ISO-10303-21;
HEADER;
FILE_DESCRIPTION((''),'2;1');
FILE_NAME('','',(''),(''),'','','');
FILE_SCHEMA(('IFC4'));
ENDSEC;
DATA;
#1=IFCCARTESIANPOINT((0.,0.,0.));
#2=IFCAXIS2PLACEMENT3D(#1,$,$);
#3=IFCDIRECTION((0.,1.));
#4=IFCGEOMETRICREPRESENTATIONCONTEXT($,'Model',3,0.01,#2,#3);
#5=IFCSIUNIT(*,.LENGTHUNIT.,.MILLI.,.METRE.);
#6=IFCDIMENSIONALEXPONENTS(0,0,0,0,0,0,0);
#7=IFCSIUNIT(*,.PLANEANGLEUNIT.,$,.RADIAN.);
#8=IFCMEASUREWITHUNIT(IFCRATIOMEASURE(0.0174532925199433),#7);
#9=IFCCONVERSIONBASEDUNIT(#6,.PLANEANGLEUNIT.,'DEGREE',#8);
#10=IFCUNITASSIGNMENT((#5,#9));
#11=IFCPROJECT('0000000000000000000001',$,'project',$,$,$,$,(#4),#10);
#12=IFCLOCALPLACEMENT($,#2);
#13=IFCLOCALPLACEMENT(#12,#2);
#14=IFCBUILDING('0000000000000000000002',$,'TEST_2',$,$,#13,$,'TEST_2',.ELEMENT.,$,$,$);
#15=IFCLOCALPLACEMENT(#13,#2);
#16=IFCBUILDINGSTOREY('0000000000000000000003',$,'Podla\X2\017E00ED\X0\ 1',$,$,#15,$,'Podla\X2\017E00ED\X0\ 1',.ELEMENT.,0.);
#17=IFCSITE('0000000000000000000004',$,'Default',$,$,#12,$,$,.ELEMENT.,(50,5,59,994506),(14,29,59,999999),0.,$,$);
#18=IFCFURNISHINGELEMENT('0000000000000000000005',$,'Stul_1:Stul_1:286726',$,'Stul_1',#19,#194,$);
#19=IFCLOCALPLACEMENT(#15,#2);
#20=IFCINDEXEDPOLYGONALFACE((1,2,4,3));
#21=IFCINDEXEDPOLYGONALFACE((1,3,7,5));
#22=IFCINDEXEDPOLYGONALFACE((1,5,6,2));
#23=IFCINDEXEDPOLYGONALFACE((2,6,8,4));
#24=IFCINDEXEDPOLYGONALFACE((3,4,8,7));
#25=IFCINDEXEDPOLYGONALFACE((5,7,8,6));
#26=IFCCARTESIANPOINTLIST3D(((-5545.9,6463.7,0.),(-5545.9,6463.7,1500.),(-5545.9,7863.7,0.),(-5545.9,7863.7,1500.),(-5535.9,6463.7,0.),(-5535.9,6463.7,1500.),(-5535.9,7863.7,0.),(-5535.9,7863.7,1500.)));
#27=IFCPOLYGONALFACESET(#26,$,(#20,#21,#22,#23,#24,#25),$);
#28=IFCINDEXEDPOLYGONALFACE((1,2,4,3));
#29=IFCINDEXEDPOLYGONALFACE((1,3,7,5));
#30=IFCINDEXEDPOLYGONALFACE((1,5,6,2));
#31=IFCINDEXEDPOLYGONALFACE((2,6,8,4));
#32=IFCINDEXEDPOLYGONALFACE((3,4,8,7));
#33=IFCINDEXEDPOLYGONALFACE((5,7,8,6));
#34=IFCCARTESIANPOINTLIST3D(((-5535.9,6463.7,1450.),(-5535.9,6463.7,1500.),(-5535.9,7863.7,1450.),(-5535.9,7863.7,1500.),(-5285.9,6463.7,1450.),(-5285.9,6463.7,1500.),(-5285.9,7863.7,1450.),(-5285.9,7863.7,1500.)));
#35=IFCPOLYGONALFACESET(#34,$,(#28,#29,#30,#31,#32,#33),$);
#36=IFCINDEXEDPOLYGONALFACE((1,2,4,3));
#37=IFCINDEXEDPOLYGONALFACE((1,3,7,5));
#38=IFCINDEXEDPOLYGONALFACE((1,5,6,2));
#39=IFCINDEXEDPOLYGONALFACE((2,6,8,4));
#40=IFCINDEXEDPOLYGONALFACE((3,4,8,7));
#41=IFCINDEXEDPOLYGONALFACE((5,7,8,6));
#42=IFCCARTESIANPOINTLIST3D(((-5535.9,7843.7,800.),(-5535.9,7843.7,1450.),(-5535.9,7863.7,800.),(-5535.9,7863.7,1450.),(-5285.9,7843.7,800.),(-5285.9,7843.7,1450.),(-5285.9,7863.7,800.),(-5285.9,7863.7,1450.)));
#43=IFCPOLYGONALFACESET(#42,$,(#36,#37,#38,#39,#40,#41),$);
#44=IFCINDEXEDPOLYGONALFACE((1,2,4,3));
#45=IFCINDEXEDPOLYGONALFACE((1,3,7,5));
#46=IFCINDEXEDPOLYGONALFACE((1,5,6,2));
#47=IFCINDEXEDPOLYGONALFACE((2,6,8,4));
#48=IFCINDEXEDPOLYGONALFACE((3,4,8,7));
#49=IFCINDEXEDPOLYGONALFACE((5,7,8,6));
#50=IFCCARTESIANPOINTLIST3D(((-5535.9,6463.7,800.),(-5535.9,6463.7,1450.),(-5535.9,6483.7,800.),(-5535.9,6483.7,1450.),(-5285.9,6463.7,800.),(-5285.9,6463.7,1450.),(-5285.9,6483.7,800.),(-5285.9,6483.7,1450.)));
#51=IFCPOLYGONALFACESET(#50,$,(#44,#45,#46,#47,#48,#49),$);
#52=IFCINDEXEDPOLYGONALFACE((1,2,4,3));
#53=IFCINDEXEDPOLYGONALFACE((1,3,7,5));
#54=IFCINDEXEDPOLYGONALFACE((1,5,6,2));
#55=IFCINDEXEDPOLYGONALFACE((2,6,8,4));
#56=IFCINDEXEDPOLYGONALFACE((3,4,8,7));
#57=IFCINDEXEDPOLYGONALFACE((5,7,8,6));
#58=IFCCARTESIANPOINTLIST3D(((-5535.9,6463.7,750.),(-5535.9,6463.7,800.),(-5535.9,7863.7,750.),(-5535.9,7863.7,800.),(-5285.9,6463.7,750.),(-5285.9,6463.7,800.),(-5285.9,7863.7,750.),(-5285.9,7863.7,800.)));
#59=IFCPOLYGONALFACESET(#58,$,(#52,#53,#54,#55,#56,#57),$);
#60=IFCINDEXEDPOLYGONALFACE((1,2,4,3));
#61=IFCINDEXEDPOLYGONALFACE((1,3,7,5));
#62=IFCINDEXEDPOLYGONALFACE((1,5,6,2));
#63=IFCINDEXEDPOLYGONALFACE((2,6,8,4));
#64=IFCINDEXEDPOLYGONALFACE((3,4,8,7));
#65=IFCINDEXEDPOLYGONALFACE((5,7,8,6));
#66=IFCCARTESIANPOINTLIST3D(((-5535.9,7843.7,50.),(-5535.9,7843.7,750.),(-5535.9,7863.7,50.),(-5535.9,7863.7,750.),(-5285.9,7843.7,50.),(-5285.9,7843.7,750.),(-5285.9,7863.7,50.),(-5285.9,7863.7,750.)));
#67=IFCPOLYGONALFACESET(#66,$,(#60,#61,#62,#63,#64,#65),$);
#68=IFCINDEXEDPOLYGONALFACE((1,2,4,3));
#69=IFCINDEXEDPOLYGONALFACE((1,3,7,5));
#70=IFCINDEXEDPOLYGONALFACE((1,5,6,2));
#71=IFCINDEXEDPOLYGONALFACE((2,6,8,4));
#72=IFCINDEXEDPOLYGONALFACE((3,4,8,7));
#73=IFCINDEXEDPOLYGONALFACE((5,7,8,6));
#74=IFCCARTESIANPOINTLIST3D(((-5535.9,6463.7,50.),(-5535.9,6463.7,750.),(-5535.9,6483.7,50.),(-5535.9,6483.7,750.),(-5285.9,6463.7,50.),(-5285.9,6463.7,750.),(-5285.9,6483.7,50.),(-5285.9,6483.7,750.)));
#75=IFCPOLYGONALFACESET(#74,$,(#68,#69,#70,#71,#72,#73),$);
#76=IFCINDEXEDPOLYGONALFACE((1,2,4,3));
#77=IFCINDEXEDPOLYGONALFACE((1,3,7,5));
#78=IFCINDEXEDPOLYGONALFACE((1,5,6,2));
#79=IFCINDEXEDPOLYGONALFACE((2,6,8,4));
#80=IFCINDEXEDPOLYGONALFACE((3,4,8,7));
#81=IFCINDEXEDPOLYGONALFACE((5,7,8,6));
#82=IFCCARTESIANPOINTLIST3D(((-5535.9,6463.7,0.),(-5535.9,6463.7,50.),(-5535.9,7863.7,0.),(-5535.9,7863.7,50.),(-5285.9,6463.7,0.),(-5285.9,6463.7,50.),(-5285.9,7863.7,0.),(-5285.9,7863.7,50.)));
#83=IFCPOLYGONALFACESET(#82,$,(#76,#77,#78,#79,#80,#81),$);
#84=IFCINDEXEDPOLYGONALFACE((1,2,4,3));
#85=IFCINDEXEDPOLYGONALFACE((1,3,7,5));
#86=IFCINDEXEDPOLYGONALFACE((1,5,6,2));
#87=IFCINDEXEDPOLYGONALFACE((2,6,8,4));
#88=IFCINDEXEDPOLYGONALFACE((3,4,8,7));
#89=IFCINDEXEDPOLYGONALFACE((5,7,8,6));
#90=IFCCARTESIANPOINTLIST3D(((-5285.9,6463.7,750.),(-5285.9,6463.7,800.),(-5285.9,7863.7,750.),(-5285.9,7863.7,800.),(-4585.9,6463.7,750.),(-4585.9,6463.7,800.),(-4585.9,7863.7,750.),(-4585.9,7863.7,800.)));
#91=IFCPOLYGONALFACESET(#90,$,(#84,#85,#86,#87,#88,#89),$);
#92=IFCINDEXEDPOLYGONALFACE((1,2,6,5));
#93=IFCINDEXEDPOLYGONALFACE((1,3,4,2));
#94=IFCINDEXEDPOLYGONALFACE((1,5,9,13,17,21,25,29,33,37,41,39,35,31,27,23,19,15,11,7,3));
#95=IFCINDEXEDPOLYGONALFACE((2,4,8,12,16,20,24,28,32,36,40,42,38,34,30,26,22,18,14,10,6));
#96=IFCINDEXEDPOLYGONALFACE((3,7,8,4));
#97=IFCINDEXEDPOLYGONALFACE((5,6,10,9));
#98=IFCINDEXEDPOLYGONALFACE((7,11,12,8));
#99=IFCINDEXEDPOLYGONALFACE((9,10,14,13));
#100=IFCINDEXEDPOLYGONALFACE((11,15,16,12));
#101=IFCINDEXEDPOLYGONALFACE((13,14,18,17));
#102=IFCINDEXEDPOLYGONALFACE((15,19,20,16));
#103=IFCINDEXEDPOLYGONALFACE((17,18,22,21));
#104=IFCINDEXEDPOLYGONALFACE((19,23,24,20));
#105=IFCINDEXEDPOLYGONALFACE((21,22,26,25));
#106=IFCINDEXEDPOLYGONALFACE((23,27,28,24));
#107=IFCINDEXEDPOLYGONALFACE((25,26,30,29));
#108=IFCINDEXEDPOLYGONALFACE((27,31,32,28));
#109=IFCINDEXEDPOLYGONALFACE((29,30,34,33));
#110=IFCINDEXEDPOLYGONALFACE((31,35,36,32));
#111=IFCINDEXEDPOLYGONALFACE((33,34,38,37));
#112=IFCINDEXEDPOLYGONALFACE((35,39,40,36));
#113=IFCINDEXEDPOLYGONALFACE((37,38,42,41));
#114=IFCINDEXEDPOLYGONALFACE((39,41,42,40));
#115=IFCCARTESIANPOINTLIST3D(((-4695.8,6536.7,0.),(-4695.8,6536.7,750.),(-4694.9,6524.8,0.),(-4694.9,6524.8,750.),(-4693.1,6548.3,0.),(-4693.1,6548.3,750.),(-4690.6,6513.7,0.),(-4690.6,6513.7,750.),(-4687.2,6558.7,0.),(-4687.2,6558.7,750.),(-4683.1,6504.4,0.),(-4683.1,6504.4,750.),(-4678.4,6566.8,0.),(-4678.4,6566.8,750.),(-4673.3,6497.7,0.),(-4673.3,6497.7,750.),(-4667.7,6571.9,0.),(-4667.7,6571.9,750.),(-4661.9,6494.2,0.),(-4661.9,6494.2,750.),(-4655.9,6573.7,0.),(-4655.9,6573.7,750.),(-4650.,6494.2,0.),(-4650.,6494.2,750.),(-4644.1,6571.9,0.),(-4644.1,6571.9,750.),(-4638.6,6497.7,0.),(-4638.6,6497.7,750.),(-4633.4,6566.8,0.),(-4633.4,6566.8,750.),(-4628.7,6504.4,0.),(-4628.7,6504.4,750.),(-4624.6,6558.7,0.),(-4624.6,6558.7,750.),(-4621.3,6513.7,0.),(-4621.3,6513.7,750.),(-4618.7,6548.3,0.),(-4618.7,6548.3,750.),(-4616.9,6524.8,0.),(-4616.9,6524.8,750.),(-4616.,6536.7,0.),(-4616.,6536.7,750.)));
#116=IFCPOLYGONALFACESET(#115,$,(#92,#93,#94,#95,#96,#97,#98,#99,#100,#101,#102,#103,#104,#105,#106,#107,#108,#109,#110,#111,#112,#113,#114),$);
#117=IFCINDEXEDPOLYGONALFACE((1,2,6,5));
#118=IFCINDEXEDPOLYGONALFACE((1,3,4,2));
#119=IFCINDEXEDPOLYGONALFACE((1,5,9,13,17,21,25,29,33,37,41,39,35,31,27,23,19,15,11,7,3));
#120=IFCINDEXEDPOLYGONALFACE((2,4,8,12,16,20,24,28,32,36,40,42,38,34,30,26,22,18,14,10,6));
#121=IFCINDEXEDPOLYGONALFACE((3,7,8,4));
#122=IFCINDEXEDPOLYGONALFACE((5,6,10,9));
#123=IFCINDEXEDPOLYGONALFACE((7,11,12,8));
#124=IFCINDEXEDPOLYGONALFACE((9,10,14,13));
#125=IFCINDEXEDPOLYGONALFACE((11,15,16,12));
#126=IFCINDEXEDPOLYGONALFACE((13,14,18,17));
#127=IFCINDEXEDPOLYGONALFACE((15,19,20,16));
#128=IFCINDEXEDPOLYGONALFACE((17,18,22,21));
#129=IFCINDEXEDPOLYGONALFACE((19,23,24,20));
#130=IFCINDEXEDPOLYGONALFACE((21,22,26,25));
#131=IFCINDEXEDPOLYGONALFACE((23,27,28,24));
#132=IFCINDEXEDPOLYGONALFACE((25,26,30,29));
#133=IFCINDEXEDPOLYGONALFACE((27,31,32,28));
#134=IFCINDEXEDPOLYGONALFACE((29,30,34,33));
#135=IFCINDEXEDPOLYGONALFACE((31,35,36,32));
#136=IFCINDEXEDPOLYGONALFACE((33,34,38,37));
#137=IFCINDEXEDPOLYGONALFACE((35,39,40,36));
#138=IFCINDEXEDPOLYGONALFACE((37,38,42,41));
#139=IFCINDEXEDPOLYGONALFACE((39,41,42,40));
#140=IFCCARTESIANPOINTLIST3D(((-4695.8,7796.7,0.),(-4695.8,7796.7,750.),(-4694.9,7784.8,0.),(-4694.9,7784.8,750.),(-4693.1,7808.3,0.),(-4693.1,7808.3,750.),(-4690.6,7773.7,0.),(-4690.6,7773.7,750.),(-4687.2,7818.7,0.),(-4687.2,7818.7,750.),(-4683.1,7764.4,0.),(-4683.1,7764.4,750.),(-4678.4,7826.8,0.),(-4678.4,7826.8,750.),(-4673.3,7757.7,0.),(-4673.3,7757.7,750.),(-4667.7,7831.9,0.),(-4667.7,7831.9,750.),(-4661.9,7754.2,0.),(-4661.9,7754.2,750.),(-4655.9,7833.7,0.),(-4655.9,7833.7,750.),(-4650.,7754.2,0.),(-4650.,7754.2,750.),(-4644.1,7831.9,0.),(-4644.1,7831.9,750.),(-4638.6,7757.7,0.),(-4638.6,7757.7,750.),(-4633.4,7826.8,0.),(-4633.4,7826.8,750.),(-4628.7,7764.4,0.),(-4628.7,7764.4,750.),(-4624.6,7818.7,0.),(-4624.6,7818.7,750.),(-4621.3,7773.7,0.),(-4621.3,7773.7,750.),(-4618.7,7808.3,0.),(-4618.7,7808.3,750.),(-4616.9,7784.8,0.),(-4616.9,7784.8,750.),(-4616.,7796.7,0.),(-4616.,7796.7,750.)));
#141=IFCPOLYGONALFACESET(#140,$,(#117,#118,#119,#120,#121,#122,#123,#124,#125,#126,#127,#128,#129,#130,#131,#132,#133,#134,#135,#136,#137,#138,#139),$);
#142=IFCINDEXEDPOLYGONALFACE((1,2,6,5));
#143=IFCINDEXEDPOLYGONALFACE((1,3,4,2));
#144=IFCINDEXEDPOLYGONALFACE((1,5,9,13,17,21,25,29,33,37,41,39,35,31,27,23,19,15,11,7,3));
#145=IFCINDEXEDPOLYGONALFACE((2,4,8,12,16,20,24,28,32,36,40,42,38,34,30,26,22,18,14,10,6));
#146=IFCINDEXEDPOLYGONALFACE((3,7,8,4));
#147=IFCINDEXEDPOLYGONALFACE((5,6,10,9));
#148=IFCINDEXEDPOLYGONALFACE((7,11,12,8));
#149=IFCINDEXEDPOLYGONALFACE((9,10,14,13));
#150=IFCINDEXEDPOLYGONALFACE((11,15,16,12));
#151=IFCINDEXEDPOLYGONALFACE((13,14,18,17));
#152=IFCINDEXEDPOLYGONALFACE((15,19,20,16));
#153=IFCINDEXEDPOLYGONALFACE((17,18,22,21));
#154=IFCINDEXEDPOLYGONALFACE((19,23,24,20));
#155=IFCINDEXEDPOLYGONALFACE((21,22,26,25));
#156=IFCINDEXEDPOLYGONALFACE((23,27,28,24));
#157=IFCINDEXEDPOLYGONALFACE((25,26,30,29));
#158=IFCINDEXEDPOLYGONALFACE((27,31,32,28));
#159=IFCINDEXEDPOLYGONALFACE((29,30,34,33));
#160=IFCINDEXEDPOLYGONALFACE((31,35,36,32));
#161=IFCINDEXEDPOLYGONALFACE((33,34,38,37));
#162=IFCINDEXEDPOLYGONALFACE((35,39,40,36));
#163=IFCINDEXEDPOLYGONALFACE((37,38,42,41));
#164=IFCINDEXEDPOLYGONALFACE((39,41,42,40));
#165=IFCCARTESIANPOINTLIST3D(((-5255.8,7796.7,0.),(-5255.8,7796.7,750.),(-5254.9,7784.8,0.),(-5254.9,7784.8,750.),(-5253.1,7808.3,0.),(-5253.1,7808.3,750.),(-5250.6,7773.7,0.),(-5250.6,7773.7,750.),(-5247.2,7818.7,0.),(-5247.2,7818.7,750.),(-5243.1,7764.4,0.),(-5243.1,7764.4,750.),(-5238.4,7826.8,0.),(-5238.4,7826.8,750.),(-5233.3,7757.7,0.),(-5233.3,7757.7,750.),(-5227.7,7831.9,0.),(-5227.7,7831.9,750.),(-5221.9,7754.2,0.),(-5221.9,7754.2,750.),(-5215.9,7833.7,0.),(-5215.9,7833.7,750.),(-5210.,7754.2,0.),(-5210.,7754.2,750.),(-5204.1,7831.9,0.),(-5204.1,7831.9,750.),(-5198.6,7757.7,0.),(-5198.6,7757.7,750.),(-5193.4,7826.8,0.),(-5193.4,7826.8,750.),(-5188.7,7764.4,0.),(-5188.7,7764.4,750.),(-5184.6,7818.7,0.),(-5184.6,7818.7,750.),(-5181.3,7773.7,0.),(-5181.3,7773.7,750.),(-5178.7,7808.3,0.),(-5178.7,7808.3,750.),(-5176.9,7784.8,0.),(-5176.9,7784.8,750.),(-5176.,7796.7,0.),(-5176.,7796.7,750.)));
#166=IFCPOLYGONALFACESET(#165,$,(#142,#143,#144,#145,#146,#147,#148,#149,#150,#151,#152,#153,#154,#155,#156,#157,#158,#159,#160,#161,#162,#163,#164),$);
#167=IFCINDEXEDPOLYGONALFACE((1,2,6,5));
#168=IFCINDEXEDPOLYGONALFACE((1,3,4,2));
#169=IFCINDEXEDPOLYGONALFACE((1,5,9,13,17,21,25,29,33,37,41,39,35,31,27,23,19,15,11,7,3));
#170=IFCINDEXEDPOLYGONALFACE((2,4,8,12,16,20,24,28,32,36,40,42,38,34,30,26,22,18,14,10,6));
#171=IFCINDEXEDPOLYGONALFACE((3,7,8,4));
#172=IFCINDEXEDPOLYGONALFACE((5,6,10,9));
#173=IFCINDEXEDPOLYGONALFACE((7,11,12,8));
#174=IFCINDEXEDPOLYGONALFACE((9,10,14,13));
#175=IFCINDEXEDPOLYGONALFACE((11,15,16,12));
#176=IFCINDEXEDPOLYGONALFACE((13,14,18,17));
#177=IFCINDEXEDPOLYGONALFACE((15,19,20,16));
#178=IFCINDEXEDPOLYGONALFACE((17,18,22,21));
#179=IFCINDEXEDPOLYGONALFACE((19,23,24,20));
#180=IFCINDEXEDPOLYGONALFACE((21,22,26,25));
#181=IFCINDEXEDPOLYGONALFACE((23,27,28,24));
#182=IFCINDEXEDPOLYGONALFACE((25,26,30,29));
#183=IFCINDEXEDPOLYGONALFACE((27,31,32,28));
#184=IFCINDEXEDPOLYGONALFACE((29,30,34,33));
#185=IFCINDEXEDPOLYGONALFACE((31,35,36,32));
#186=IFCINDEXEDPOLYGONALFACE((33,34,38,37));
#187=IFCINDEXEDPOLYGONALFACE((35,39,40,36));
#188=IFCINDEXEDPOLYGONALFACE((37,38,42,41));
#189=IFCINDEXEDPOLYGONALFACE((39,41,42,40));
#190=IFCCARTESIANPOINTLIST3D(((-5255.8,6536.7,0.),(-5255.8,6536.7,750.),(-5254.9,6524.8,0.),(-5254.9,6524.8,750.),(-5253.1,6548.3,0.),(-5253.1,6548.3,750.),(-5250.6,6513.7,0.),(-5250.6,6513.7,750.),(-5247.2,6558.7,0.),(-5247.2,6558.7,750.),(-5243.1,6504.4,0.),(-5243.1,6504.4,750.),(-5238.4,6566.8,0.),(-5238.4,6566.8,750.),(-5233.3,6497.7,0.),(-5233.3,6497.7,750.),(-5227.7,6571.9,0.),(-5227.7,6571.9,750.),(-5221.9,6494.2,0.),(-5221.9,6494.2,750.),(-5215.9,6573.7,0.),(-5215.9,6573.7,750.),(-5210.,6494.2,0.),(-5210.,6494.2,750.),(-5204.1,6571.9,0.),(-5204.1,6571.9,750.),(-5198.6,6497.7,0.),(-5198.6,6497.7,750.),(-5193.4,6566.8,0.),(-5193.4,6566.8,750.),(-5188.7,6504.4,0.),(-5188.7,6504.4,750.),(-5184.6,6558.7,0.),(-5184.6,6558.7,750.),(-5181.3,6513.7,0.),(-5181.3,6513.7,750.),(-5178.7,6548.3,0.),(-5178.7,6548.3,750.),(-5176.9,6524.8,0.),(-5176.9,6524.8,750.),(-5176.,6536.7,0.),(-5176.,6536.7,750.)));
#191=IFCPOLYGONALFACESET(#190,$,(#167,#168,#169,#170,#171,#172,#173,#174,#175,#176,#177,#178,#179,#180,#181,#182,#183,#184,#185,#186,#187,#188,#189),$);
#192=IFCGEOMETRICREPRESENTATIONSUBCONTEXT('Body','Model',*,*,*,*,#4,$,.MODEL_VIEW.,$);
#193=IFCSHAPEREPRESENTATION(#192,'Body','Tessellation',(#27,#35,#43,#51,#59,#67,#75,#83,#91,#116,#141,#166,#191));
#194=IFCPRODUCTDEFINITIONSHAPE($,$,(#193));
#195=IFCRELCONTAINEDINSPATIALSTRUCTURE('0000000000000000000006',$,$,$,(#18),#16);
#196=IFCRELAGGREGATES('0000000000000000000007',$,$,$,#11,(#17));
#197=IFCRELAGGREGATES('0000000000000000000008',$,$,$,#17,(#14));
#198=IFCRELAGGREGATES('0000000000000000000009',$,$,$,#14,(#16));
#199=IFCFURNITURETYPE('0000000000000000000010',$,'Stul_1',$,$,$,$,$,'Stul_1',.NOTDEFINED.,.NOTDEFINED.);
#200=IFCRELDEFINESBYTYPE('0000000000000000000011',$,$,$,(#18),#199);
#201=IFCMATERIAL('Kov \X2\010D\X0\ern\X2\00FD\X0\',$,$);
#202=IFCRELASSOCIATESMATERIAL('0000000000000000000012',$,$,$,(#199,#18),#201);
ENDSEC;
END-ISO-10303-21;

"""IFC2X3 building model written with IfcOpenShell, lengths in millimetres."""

from ifc_helpers import new_model, entity, si_unit, converted_unit, direction, frame, frame_2d, origin, origin_2d_with_axis, place, context, subcontext, project, spatial, rectangle, circle, extrude, source, transform, mapped, material, type_object, type_shapes, element, save


model = new_model("IFC2X3")

# Units and contexts
model_context = context("Model", 3, precision=0.01, world=origin(), true_north=direction((0.0, 1.0)))
body_context = subcontext(model_context, "Body", "Model", "MODEL_VIEW")
ifc_project = project(units=[si_unit("LENGTHUNIT", "METRE", prefix="MILLI"), converted_unit("PLANEANGLEUNIT", "DEGREE", entity("IfcRatioMeasure", 0.0174532925199433), si_unit("PLANEANGLEUNIT", "RADIAN"), dimensions=[0, 0, 0, 0, 0, 0, 0])], contexts=[model_context])

# Site, building, storey
site_placement = place(None, origin())
site = spatial("IfcSite", under=ifc_project, at=site_placement, Name="Default", CompositionType="ELEMENT", RefLatitude=(50, 5, 59, 994506), RefLongitude=(14, 29, 59, 999999), RefElevation=0.0)
building_placement = place(site_placement, origin())
building = spatial("IfcBuilding", under=site, at=building_placement, Name="TEST_2", LongName="TEST_2", CompositionType="ELEMENT")
storey_placement = place(building_placement, origin())
storey = spatial("IfcBuildingStorey", under=building, at=storey_placement, Name="Podlaží 1", LongName="Podlaží 1", CompositionType="ELEMENT", Elevation=0.0)

# Furnishing element
ifc_material_1 = material(Name="Kov černý")
furniture_type = type_object("IfcFurnitureType", Name="Stul_1", ElementType="Stul_1", material=ifc_material_1)
shared_shape_1 = source(origin(), body_context, "Body", "SweptSolid", [
    extrude(rectangle(XDim=1400.0, YDim=10.0, at=origin_2d_with_axis()), frame((0.0, 605.0, 0.0), z_axis=(0.0, 0.0, 1.0), x_axis=(-1.0, 0.0, 0.0)), (0.0, 0.0, 1.0), 1500.0),
    extrude(rectangle(XDim=1400.0, YDim=250.0, at=frame_2d((0.0, 0.0), x_axis=(1.0, 0.0))), frame((0.0, 475.0, 1450.0), z_axis=(0.0, 0.0, 1.0), x_axis=(-1.0, 0.0, 0.0)), (0.0, 0.0, 1.0), 50.0),
    extrude(rectangle(XDim=20.0, YDim=250.0, at=origin_2d_with_axis()), frame((690.0, 475.0, 800.0), z_axis=(0.0, 0.0, 1.0), x_axis=(-1.0, 0.0, 0.0)), (0.0, 0.0, 1.0), 650.0),
    extrude(rectangle(XDim=20.0, YDim=250.0, at=frame_2d((0.0, 0.0), x_axis=(1.0, 0.0))), frame((-690.0, 475.0, 800.0), z_axis=(0.0, 0.0, 1.0), x_axis=(-1.0, 0.0, 0.0)), (0.0, 0.0, 1.0), 650.0),
    extrude(rectangle(XDim=1400.0, YDim=250.0, at=origin_2d_with_axis()), frame((0.0, 475.0, 750.0), z_axis=(0.0, 0.0, 1.0), x_axis=(-1.0, 0.0, 0.0)), (0.0, 0.0, 1.0), 50.0),
    extrude(rectangle(XDim=20.0, YDim=250.0, at=origin_2d_with_axis()), frame((690.0, 475.0, 50.0), z_axis=(0.0, 0.0, 1.0), x_axis=(-1.0, 0.0, 0.0)), (0.0, 0.0, 1.0), 700.0),
    extrude(rectangle(XDim=20.0, YDim=250.0, at=frame_2d((0.0, 0.0), x_axis=(1.0, 0.0))), frame((-690.0, 475.0, 50.0), z_axis=(0.0, 0.0, 1.0), x_axis=(-1.0, 0.0, 0.0)), (0.0, 0.0, 1.0), 700.0),
    extrude(rectangle(XDim=1400.0, YDim=250.0, at=origin_2d_with_axis()), frame((0.0, 475.0, 0.0), z_axis=(0.0, 0.0, 1.0), x_axis=(-1.0, 0.0, 0.0)), (0.0, 0.0, 1.0), 50.0),
    extrude(rectangle(XDim=1400.0, YDim=700.0, at=origin_2d_with_axis()), frame((0.0, 0.0, 750.0), z_axis=(0.0, 0.0, 1.0), x_axis=(-1.0, 0.0, 0.0)), (0.0, 0.0, 1.0), 50.0),
    extrude(circle(Radius=40.0, at=frame_2d((0.0, 0.0), x_axis=(1.0, 0.0))), frame((-630.0, -280.0, 0.0)), (0.0, 0.0, 1.0), 750.0),
    extrude(circle(Radius=40.0, at=frame_2d((0.0, 0.0), x_axis=(1.0, 0.0))), frame((630.0, -280.0, 0.0)), (0.0, 0.0, 1.0), 750.0),
    extrude(circle(Radius=40.0, at=frame_2d((0.0, 0.0), x_axis=(1.0, 0.0))), frame((630.0, 280.0, 0.0)), (0.0, 0.0, 1.0), 750.0),
    extrude(circle(Radius=40.0, at=frame_2d((0.0, 0.0), x_axis=(1.0, 0.0))), frame((-630.0, 280.0, 0.0)), (0.0, 0.0, 1.0), 750.0),
])
type_shapes(furniture_type, [shared_shape_1])
for number, where, z_axis, x_axis, name in (
    (1, (-4935.9, 7163.7, 0.0), (0.0, 0.0, 1.0), (0.0, 1.0, 0.0), "Stul_1:Stul_1:286726"),
):
    element("IfcFurnishingElement", number, at=place(storey_placement, frame(where, z_axis=z_axis, x_axis=x_axis)), inside=storey, type_object=furniture_type, material=ifc_material_1, Name=name, ObjectType="Stul_1", context=body_context, shape_type="MappedRepresentation", body=[
        mapped(shared_shape_1, transform((0.0, 0.0, 0.0), scale=1.0)),
    ])

save(model, "model.ifc")
